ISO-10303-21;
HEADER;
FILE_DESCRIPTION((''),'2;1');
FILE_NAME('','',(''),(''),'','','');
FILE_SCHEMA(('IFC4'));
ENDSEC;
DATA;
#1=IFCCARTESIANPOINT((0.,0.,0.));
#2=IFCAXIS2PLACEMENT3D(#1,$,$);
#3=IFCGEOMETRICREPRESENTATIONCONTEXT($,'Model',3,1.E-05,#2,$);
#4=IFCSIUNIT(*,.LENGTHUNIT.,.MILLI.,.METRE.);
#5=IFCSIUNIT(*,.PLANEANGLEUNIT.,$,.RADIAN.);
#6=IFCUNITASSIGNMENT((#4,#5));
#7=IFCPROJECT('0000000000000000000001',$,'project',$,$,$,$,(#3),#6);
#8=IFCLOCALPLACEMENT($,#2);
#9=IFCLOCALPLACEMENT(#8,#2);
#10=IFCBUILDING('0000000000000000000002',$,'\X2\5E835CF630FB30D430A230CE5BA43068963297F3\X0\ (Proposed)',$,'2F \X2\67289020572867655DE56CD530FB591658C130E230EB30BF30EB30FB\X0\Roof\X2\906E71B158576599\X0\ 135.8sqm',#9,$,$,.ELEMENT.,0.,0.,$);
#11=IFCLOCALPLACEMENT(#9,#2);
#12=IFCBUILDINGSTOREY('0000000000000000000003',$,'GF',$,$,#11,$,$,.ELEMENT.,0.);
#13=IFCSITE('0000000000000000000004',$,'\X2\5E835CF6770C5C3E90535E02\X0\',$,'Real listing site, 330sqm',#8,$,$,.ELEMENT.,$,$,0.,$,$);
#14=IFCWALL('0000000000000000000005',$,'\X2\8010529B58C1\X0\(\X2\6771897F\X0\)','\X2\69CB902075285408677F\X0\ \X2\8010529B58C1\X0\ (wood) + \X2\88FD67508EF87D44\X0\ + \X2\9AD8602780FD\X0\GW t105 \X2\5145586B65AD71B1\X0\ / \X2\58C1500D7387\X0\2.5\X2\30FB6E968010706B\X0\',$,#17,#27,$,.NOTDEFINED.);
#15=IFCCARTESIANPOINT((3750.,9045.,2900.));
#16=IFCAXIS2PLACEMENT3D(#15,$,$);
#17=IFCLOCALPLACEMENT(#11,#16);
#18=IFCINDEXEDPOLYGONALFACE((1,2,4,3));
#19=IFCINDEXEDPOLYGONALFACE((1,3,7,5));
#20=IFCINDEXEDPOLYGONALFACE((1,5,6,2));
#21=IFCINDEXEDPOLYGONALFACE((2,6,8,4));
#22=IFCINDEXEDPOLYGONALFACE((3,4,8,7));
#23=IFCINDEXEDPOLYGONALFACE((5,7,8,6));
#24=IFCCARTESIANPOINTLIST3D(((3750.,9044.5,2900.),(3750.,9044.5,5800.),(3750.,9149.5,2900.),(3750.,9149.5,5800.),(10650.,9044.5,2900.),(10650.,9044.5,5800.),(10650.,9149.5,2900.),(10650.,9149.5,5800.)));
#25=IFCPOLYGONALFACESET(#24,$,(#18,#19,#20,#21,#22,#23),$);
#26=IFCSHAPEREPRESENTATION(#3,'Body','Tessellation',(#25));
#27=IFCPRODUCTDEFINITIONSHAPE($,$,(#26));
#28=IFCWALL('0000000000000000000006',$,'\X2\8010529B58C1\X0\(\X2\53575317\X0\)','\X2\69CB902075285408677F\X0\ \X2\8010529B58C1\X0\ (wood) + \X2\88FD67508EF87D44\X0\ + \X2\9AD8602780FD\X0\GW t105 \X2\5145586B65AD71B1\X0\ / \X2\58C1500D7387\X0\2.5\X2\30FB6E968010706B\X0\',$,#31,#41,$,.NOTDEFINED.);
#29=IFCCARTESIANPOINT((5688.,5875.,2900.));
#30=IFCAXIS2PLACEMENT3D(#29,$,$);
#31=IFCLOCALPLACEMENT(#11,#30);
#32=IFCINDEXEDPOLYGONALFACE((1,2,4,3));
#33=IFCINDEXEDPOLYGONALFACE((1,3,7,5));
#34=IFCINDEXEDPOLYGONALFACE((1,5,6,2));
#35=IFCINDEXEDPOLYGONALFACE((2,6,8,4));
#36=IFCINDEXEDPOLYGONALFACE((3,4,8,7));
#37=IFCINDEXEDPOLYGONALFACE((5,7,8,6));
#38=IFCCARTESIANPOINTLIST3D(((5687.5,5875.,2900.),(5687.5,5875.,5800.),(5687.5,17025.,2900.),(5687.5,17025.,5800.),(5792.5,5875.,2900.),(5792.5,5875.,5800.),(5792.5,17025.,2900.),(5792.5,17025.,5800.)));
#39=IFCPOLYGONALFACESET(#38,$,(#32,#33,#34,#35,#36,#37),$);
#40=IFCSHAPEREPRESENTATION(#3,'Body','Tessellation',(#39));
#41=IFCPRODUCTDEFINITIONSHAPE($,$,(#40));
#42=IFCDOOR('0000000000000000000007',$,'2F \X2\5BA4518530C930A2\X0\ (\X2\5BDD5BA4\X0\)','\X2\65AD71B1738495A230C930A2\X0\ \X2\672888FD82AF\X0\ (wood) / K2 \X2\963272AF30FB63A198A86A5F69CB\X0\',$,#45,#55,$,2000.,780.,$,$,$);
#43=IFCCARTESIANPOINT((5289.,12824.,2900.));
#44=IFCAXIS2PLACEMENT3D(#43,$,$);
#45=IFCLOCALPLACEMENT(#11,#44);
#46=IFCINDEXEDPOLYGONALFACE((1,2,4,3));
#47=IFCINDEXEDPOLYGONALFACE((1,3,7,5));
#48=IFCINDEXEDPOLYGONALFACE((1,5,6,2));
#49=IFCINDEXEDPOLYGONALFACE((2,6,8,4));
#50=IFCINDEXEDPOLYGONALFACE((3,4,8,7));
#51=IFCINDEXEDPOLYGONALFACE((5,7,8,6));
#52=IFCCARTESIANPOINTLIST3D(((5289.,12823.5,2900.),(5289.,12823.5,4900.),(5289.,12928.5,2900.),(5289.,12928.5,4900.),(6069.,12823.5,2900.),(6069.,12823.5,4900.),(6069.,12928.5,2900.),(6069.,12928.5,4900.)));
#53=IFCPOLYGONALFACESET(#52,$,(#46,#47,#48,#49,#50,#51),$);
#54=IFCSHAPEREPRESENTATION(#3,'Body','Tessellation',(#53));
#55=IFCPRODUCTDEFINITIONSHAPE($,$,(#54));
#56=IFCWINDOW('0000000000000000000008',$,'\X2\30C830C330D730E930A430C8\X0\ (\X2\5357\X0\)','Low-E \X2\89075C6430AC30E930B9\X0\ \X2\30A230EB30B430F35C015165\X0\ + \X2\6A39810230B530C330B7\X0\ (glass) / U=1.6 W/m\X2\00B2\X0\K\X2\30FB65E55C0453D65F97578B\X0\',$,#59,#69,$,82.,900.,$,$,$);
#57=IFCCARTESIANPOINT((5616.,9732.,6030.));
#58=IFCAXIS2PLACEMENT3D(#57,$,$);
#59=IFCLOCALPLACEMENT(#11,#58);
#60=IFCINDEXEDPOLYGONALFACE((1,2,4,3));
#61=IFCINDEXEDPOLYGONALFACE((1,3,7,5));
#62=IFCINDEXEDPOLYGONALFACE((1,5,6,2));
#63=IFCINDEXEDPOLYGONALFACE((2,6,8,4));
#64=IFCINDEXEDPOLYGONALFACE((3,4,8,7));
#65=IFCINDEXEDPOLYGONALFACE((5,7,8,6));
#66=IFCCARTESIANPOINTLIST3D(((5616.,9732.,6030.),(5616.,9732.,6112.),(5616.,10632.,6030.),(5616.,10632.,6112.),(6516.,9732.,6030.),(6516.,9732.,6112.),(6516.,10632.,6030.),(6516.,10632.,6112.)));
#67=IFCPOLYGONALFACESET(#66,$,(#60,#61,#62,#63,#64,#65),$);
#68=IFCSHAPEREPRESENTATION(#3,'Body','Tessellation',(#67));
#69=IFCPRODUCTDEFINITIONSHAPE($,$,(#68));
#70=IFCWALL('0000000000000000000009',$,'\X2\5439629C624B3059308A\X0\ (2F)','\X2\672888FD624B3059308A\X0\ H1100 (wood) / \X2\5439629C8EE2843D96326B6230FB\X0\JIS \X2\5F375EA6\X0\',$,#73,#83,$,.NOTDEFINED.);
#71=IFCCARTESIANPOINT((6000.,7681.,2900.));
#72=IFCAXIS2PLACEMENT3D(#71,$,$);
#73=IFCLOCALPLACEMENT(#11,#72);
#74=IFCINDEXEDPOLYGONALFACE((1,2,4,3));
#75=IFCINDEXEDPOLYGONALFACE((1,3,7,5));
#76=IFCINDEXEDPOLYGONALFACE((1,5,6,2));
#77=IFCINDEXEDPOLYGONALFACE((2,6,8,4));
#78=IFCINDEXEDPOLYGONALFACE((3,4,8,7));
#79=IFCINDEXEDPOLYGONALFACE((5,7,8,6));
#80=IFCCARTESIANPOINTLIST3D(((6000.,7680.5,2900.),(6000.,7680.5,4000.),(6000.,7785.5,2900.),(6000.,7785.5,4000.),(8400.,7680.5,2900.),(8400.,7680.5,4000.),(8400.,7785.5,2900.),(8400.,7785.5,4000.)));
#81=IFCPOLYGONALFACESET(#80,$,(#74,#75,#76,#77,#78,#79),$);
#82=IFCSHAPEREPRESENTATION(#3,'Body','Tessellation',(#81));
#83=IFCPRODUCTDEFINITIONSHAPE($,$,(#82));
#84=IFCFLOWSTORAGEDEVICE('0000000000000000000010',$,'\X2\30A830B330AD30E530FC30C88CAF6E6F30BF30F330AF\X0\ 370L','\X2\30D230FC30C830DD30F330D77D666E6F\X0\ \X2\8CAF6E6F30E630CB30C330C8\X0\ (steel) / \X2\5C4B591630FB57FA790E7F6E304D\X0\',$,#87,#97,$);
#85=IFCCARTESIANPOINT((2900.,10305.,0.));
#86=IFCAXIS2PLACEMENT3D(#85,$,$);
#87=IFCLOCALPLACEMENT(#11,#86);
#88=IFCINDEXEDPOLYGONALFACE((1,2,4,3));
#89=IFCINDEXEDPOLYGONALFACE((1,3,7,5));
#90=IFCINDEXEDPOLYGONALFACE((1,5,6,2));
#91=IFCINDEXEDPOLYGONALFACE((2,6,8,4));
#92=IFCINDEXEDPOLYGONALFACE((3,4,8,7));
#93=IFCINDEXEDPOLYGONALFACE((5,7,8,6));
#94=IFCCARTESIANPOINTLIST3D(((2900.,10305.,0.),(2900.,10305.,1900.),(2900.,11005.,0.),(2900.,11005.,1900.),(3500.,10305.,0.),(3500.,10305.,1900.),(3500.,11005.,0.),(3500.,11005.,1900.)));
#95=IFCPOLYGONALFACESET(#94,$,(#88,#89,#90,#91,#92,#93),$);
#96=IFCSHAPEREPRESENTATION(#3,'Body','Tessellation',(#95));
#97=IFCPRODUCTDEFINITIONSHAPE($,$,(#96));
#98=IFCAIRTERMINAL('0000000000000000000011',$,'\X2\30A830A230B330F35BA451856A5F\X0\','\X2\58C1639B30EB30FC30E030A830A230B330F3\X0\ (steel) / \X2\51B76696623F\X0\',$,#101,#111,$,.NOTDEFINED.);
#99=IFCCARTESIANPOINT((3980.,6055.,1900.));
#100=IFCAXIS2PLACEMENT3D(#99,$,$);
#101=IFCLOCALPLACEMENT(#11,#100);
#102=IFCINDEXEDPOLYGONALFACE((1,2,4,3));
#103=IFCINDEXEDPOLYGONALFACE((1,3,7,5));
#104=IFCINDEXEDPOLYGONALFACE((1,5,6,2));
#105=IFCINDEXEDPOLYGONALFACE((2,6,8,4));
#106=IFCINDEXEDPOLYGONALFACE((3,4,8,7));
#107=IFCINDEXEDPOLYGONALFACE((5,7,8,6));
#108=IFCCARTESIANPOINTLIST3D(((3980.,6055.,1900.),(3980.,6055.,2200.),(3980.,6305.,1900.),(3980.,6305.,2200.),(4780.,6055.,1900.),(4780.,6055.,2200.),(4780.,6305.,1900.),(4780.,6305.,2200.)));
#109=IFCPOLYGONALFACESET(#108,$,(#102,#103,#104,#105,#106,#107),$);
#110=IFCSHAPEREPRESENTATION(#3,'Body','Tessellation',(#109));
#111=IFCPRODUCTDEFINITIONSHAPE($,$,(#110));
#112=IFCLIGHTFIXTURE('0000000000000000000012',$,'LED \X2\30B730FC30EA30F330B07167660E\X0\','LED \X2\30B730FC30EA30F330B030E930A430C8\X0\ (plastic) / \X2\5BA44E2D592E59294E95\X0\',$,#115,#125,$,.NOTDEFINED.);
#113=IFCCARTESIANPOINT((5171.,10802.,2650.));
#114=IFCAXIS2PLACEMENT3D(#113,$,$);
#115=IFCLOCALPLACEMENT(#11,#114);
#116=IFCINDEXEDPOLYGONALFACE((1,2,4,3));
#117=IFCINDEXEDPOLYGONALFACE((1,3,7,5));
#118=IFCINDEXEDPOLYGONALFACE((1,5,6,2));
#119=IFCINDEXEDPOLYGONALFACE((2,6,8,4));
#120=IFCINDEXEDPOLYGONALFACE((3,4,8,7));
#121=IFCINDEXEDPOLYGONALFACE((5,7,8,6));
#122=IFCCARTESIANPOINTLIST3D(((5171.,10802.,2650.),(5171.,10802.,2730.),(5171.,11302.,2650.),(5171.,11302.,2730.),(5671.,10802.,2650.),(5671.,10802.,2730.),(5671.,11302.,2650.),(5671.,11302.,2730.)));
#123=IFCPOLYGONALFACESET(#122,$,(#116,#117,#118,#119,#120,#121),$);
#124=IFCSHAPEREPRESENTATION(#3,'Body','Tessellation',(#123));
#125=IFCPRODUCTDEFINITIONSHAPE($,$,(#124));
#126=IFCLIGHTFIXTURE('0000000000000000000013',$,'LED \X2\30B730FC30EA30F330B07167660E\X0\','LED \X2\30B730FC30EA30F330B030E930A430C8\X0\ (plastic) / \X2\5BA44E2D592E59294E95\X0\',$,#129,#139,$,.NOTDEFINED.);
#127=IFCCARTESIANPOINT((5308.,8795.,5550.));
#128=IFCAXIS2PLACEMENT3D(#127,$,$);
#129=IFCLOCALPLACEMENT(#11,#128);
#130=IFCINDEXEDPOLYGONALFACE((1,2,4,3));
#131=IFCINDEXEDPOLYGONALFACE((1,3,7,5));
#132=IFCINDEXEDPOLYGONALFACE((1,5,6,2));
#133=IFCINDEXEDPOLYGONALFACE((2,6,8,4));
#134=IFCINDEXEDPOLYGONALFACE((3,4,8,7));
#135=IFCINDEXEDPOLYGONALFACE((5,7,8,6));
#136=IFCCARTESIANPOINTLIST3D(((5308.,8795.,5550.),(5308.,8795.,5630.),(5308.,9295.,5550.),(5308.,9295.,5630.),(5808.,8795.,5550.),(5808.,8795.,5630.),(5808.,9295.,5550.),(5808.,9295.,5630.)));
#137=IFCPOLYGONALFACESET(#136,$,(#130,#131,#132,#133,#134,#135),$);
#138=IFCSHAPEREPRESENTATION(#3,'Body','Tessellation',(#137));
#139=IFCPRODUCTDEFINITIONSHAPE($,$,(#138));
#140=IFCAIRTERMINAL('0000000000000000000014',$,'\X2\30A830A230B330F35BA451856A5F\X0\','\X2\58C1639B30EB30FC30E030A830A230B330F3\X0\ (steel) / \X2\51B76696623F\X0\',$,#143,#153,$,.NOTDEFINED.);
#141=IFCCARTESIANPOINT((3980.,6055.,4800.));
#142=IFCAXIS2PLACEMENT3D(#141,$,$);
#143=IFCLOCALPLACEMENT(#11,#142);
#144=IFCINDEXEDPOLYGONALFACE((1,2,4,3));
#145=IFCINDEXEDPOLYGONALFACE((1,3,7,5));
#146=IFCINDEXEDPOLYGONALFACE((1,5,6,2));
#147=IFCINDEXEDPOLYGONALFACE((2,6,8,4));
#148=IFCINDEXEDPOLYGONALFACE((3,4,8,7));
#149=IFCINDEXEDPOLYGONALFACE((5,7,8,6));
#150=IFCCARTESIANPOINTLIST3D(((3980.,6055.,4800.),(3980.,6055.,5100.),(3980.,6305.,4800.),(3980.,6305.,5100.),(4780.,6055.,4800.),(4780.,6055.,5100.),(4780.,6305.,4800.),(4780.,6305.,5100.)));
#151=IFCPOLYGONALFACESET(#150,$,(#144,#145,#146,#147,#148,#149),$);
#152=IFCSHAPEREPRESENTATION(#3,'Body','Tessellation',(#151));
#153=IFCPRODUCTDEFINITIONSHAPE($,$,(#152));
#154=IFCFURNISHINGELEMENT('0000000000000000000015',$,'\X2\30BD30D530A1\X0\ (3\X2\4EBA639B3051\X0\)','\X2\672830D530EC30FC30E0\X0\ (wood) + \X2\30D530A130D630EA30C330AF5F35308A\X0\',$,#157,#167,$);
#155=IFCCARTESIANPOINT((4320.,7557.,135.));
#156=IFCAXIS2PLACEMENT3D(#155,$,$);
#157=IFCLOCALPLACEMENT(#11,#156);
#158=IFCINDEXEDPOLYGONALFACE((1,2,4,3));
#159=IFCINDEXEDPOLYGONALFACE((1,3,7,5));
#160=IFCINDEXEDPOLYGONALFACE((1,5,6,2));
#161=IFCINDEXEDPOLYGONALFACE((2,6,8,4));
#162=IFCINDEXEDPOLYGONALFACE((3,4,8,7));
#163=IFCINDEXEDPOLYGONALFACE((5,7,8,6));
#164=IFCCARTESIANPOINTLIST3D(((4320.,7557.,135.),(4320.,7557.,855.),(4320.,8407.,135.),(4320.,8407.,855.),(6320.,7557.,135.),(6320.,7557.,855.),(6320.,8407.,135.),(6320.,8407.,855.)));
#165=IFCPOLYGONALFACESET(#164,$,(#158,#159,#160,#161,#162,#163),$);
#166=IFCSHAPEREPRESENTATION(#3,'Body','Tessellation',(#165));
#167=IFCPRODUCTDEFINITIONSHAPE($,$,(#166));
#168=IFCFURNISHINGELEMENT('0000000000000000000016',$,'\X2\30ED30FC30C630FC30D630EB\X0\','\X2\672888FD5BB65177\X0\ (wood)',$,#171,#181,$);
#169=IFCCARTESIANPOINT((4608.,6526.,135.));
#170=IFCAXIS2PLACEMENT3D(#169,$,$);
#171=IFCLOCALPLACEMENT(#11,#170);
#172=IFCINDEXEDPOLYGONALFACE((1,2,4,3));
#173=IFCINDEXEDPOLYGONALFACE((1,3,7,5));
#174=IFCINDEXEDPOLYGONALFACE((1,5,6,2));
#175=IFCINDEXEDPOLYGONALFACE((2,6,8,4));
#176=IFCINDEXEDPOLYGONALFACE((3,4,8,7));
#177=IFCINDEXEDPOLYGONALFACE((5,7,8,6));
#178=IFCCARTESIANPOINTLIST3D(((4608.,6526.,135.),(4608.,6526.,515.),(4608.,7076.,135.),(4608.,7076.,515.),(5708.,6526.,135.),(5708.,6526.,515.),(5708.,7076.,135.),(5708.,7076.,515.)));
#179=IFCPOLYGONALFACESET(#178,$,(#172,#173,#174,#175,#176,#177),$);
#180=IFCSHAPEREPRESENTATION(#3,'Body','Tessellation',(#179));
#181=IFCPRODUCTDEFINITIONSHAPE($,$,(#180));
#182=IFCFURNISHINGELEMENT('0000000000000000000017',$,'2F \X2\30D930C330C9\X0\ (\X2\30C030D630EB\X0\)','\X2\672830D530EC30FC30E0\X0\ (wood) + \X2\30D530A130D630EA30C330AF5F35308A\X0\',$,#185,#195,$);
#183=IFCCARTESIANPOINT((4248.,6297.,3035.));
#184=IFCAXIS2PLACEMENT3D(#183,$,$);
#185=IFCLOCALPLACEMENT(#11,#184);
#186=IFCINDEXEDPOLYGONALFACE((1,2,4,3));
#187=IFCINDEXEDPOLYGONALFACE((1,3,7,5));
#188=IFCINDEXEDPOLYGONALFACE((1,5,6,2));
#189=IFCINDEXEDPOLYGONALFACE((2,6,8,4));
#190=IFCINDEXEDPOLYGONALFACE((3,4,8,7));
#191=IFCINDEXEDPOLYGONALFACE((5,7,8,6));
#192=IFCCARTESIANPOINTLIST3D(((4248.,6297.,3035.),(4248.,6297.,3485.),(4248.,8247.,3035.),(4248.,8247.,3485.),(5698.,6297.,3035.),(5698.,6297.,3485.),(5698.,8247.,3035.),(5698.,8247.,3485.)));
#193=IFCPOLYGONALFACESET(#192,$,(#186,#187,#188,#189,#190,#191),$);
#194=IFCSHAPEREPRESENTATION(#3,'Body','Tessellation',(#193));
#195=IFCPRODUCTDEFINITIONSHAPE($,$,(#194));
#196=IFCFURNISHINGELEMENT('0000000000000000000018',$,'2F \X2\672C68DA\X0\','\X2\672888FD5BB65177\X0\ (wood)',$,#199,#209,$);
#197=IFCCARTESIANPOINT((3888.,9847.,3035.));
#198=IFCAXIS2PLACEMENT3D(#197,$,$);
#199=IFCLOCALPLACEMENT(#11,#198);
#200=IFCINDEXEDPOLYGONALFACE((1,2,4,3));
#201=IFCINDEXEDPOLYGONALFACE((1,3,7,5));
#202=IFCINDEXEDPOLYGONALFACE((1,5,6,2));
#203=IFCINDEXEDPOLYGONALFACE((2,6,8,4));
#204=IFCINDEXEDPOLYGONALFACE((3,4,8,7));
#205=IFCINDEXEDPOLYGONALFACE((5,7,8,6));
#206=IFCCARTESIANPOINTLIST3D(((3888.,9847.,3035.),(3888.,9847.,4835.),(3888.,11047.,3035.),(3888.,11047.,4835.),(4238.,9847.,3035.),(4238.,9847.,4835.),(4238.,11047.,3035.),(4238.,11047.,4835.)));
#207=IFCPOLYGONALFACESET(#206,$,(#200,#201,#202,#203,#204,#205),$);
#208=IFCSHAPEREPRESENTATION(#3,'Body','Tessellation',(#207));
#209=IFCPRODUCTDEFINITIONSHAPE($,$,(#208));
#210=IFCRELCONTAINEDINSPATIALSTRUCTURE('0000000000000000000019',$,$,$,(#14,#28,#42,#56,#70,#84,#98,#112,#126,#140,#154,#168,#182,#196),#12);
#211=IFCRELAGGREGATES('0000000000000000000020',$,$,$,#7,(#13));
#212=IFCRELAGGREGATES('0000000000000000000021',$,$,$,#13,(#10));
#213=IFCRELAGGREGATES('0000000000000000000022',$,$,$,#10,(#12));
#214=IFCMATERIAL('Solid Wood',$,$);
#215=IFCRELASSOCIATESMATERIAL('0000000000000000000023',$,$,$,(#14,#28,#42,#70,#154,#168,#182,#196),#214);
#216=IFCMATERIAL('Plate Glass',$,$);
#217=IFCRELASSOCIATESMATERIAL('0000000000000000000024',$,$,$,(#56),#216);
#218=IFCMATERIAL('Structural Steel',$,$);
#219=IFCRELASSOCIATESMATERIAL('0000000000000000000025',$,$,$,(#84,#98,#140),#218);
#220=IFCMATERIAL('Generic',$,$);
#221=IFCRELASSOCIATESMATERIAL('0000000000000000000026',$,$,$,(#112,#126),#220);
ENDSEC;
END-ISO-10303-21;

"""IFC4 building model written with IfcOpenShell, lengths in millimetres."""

from ifc_helpers import new_model, si_unit, frame, frame_2d, origin, place, context, project, spatial, rectangle, extrude, material, element, fill, save


model = new_model("IFC4")

# Units and contexts
model_context = context("Model", 3, precision=1e-05, world=origin())
ifc_project = project(units=[si_unit("LENGTHUNIT", "METRE", prefix="MILLI"), si_unit("PLANEANGLEUNIT", "RADIAN")], contexts=[model_context])

# Site, building, storey
site_placement = place(None, origin())
site = spatial("IfcSite", under=ifc_project, at=site_placement, Name="広島県尾道市", ObjectType="Real listing site, 330sqm", CompositionType="ELEMENT", RefElevation=0.0)
building_placement = place(site_placement, origin())
building = spatial("IfcBuilding", under=site, at=building_placement, Name="広島・ピアノ室と防音 (Proposed)", ObjectType="2F 木造在来工法・外壁モルタル・Roof遮熱塗料 135.8sqm", CompositionType="ELEMENT", ElevationOfRefHeight=0.0, ElevationOfTerrain=0.0)
storey_placement = place(building_placement, origin())
storey = spatial("IfcBuildingStorey", under=building, at=storey_placement, Name="GF", CompositionType="ELEMENT", Elevation=0.0)

# Shared definitions
ifc_material_1 = material(Name="Solid Wood")

# Wall
wall_1_placement = place(storey_placement, frame((3750.0, 9045.0, 2900.0)))
element("IfcWall", 1, at=wall_1_placement, inside=storey, material=ifc_material_1, Name="耐力壁(東西)", Description="構造用合板 耐力壁 (wood) + 製材軸組 + 高性能GW t105 充填断熱 / 壁倍率2.5・準耐火", PredefinedType="NOTDEFINED", context=model_context, shape_type="SweptSolid", body=[
    extrude(rectangle(XDim=6900.0, YDim=105.0, at=frame_2d((3450.0, 52.0))), frame((3750.0, 9045.0, 2900.0)), (0.0, 0.0, 1.0), 2900.0),
])

# Wall, opening, door
wall_2_placement = place(storey_placement, frame((5688.0, 5875.0, 2900.0)))
wall_2 = element("IfcWall", 2, at=wall_2_placement, inside=storey, material=ifc_material_1, Name="耐力壁(南北)", Description="構造用合板 耐力壁 (wood) + 製材軸組 + 高性能GW t105 充填断熱 / 壁倍率2.5・準耐火", PredefinedType="NOTDEFINED", context=model_context, shape_type="SweptSolid", body=[
    extrude(rectangle(XDim=105.0, YDim=11150.0, at=frame_2d((52.0, 5575.0))), frame((5688.0, 5875.0, 2900.0)), (0.0, 0.0, 1.0), 2900.0),
])
opening_placement = place(storey_placement, frame((5289.0, 12824.0, 2900.0)))
opening = element("IfcOpeningElement", 3, at=opening_placement, cuts=wall_2, PredefinedType="NOTDEFINED", context=model_context, shape_type="SweptSolid", body=[
    extrude(rectangle(XDim=780.0, YDim=105.0, at=frame_2d((390.0, 52.0))), frame((5289.0, 12824.0, 2900.0)), (0.0, 0.0, 1.0), 2000.0),
])
door_placement = place(storey_placement, frame((5289.0, 12824.0, 2900.0)))
door = element("IfcDoor", 4, at=door_placement, inside=storey, material=ifc_material_1, Name="2F 室内ドア (寝室)", Description="断熱玄関ドア 木製芯 (wood) / K2 防犯・採風機構", OverallHeight=2000.0, OverallWidth=780.0, context=model_context, shape_type="SweptSolid", body=[
    extrude(rectangle(XDim=780.0, YDim=105.0, at=frame_2d((390.0, 52.0))), frame((5289.0, 12824.0, 2900.0)), (0.0, 0.0, 1.0), 2000.0),
])
fill(opening, door)

# Window
ifc_material_2 = material(Name="Plate Glass")
window_placement = place(storey_placement, frame((5616.0, 9732.0, 6030.0)))
element("IfcWindow", 5, at=window_placement, inside=storey, material=ifc_material_2, Name="トップライト (南)", Description="Low-E 複層ガラス アルゴン封入 + 樹脂サッシ (glass) / U=1.6 W/m²K・日射取得型", OverallHeight=82.0, OverallWidth=900.0, context=model_context, shape_type="SweptSolid", body=[
    extrude(rectangle(XDim=900.0, YDim=900.0, at=frame_2d((450.0, 450.0))), frame((5616.0, 9732.0, 6030.0)), (0.0, 0.0, 1.0), 82.0),
])

# Wall
wall_3_placement = place(storey_placement, frame((6000.0, 7681.0, 2900.0)))
element("IfcWall", 6, at=wall_3_placement, inside=storey, material=ifc_material_1, Name="吹抜手すり (2F)", Description="木製手すり H1100 (wood) / 吹抜転落防止・JIS 強度", PredefinedType="NOTDEFINED", context=model_context, shape_type="SweptSolid", body=[
    extrude(rectangle(XDim=2400.0, YDim=105.0, at=frame_2d((1200.0, 52.0))), frame((6000.0, 7681.0, 2900.0)), (0.0, 0.0, 1.0), 1100.0),
])

# Flow storage device
ifc_material_3 = material(Name="Structural Steel")
flow_storage_device_placement = place(storey_placement, frame((2900.0, 10305.0, 0.0)))
element("IfcFlowStorageDevice", 7, at=flow_storage_device_placement, inside=storey, material=ifc_material_3, Name="エコキュート貯湯タンク 370L", Description="ヒートポンプ給湯 貯湯ユニット (steel) / 屋外・基礎置き", context=model_context, shape_type="SweptSolid", body=[
    extrude(rectangle(XDim=600.0, YDim=700.0, at=frame_2d((300.0, 350.0))), frame((2900.0, 10305.0, 0.0)), (0.0, 0.0, 1.0), 1900.0),
])

# Air terminal
air_terminal_1_placement = place(storey_placement, frame((3980.0, 6055.0, 1900.0)))
element("IfcAirTerminal", 8, at=air_terminal_1_placement, inside=storey, material=ifc_material_3, Name="エアコン室内機", Description="壁掛ルームエアコン (steel) / 冷暖房", PredefinedType="NOTDEFINED", context=model_context, shape_type="SweptSolid", body=[
    extrude(rectangle(XDim=800.0, YDim=250.0, at=frame_2d((400.0, 125.0))), frame((3980.0, 6055.0, 1900.0)), (0.0, 0.0, 1.0), 300.0),
])

# Light fixtures
ifc_material_4 = material(Name="Generic")
light_fixture_1_placement = place(storey_placement, frame((5171.0, 10802.0, 2650.0)))
element("IfcLightFixture", 9, at=light_fixture_1_placement, inside=storey, material=ifc_material_4, Name="LED シーリング照明", Description="LED シーリングライト (plastic) / 室中央天井", PredefinedType="NOTDEFINED", context=model_context, shape_type="SweptSolid", body=[
    extrude(rectangle(XDim=500.0, YDim=500.0, at=frame_2d((250.0, 250.0))), frame((5171.0, 10802.0, 2650.0)), (0.0, 0.0, 1.0), 80.0),
])
light_fixture_2_placement = place(storey_placement, frame((5308.0, 8795.0, 5550.0)))
element("IfcLightFixture", 10, at=light_fixture_2_placement, inside=storey, material=ifc_material_4, Name="LED シーリング照明", Description="LED シーリングライト (plastic) / 室中央天井", PredefinedType="NOTDEFINED", context=model_context, shape_type="SweptSolid", body=[
    extrude(rectangle(XDim=500.0, YDim=500.0, at=frame_2d((250.0, 250.0))), frame((5308.0, 8795.0, 5550.0)), (0.0, 0.0, 1.0), 80.0),
])

# Air terminal
air_terminal_2_placement = place(storey_placement, frame((3980.0, 6055.0, 4800.0)))
element("IfcAirTerminal", 11, at=air_terminal_2_placement, inside=storey, material=ifc_material_3, Name="エアコン室内機", Description="壁掛ルームエアコン (steel) / 冷暖房", PredefinedType="NOTDEFINED", context=model_context, shape_type="SweptSolid", body=[
    extrude(rectangle(XDim=800.0, YDim=250.0, at=frame_2d((400.0, 125.0))), frame((3980.0, 6055.0, 4800.0)), (0.0, 0.0, 1.0), 300.0),
])

# Furnishing elements
furnishing_1_placement = place(storey_placement, frame((4320.0, 7557.0, 135.0)))
element("IfcFurnishingElement", 12, at=furnishing_1_placement, inside=storey, material=ifc_material_1, Name="ソファ (3人掛け)", Description="木フレーム (wood) + ファブリック張り", context=model_context, shape_type="SweptSolid", body=[
    extrude(rectangle(XDim=2000.0, YDim=850.0, at=frame_2d((1000.0, 425.0))), frame((4320.0, 7557.0, 135.0)), (0.0, 0.0, 1.0), 720.0),
])
furnishing_2_placement = place(storey_placement, frame((4608.0, 6526.0, 135.0)))
element("IfcFurnishingElement", 13, at=furnishing_2_placement, inside=storey, material=ifc_material_1, Name="ローテーブル", Description="木製家具 (wood)", context=model_context, shape_type="SweptSolid", body=[
    extrude(rectangle(XDim=1100.0, YDim=550.0, at=frame_2d((550.0, 275.0))), frame((4608.0, 6526.0, 135.0)), (0.0, 0.0, 1.0), 380.0),
])
furnishing_3_placement = place(storey_placement, frame((4248.0, 6297.0, 3035.0)))
element("IfcFurnishingElement", 14, at=furnishing_3_placement, inside=storey, material=ifc_material_1, Name="2F ベッド (ダブル)", Description="木フレーム (wood) + ファブリック張り", context=model_context, shape_type="SweptSolid", body=[
    extrude(rectangle(XDim=1450.0, YDim=1950.0, at=frame_2d((725.0, 975.0))), frame((4248.0, 6297.0, 3035.0)), (0.0, 0.0, 1.0), 450.0),
])
furnishing_4_placement = place(storey_placement, frame((3888.0, 9847.0, 3035.0)))
element("IfcFurnishingElement", 15, at=furnishing_4_placement, inside=storey, material=ifc_material_1, Name="2F 本棚", Description="木製家具 (wood)", context=model_context, shape_type="SweptSolid", body=[
    extrude(rectangle(XDim=350.0, YDim=1200.0, at=frame_2d((175.0, 600.0))), frame((3888.0, 9847.0, 3035.0)), (0.0, 0.0, 1.0), 1800.0),
])

save(model, "model.ifc")
